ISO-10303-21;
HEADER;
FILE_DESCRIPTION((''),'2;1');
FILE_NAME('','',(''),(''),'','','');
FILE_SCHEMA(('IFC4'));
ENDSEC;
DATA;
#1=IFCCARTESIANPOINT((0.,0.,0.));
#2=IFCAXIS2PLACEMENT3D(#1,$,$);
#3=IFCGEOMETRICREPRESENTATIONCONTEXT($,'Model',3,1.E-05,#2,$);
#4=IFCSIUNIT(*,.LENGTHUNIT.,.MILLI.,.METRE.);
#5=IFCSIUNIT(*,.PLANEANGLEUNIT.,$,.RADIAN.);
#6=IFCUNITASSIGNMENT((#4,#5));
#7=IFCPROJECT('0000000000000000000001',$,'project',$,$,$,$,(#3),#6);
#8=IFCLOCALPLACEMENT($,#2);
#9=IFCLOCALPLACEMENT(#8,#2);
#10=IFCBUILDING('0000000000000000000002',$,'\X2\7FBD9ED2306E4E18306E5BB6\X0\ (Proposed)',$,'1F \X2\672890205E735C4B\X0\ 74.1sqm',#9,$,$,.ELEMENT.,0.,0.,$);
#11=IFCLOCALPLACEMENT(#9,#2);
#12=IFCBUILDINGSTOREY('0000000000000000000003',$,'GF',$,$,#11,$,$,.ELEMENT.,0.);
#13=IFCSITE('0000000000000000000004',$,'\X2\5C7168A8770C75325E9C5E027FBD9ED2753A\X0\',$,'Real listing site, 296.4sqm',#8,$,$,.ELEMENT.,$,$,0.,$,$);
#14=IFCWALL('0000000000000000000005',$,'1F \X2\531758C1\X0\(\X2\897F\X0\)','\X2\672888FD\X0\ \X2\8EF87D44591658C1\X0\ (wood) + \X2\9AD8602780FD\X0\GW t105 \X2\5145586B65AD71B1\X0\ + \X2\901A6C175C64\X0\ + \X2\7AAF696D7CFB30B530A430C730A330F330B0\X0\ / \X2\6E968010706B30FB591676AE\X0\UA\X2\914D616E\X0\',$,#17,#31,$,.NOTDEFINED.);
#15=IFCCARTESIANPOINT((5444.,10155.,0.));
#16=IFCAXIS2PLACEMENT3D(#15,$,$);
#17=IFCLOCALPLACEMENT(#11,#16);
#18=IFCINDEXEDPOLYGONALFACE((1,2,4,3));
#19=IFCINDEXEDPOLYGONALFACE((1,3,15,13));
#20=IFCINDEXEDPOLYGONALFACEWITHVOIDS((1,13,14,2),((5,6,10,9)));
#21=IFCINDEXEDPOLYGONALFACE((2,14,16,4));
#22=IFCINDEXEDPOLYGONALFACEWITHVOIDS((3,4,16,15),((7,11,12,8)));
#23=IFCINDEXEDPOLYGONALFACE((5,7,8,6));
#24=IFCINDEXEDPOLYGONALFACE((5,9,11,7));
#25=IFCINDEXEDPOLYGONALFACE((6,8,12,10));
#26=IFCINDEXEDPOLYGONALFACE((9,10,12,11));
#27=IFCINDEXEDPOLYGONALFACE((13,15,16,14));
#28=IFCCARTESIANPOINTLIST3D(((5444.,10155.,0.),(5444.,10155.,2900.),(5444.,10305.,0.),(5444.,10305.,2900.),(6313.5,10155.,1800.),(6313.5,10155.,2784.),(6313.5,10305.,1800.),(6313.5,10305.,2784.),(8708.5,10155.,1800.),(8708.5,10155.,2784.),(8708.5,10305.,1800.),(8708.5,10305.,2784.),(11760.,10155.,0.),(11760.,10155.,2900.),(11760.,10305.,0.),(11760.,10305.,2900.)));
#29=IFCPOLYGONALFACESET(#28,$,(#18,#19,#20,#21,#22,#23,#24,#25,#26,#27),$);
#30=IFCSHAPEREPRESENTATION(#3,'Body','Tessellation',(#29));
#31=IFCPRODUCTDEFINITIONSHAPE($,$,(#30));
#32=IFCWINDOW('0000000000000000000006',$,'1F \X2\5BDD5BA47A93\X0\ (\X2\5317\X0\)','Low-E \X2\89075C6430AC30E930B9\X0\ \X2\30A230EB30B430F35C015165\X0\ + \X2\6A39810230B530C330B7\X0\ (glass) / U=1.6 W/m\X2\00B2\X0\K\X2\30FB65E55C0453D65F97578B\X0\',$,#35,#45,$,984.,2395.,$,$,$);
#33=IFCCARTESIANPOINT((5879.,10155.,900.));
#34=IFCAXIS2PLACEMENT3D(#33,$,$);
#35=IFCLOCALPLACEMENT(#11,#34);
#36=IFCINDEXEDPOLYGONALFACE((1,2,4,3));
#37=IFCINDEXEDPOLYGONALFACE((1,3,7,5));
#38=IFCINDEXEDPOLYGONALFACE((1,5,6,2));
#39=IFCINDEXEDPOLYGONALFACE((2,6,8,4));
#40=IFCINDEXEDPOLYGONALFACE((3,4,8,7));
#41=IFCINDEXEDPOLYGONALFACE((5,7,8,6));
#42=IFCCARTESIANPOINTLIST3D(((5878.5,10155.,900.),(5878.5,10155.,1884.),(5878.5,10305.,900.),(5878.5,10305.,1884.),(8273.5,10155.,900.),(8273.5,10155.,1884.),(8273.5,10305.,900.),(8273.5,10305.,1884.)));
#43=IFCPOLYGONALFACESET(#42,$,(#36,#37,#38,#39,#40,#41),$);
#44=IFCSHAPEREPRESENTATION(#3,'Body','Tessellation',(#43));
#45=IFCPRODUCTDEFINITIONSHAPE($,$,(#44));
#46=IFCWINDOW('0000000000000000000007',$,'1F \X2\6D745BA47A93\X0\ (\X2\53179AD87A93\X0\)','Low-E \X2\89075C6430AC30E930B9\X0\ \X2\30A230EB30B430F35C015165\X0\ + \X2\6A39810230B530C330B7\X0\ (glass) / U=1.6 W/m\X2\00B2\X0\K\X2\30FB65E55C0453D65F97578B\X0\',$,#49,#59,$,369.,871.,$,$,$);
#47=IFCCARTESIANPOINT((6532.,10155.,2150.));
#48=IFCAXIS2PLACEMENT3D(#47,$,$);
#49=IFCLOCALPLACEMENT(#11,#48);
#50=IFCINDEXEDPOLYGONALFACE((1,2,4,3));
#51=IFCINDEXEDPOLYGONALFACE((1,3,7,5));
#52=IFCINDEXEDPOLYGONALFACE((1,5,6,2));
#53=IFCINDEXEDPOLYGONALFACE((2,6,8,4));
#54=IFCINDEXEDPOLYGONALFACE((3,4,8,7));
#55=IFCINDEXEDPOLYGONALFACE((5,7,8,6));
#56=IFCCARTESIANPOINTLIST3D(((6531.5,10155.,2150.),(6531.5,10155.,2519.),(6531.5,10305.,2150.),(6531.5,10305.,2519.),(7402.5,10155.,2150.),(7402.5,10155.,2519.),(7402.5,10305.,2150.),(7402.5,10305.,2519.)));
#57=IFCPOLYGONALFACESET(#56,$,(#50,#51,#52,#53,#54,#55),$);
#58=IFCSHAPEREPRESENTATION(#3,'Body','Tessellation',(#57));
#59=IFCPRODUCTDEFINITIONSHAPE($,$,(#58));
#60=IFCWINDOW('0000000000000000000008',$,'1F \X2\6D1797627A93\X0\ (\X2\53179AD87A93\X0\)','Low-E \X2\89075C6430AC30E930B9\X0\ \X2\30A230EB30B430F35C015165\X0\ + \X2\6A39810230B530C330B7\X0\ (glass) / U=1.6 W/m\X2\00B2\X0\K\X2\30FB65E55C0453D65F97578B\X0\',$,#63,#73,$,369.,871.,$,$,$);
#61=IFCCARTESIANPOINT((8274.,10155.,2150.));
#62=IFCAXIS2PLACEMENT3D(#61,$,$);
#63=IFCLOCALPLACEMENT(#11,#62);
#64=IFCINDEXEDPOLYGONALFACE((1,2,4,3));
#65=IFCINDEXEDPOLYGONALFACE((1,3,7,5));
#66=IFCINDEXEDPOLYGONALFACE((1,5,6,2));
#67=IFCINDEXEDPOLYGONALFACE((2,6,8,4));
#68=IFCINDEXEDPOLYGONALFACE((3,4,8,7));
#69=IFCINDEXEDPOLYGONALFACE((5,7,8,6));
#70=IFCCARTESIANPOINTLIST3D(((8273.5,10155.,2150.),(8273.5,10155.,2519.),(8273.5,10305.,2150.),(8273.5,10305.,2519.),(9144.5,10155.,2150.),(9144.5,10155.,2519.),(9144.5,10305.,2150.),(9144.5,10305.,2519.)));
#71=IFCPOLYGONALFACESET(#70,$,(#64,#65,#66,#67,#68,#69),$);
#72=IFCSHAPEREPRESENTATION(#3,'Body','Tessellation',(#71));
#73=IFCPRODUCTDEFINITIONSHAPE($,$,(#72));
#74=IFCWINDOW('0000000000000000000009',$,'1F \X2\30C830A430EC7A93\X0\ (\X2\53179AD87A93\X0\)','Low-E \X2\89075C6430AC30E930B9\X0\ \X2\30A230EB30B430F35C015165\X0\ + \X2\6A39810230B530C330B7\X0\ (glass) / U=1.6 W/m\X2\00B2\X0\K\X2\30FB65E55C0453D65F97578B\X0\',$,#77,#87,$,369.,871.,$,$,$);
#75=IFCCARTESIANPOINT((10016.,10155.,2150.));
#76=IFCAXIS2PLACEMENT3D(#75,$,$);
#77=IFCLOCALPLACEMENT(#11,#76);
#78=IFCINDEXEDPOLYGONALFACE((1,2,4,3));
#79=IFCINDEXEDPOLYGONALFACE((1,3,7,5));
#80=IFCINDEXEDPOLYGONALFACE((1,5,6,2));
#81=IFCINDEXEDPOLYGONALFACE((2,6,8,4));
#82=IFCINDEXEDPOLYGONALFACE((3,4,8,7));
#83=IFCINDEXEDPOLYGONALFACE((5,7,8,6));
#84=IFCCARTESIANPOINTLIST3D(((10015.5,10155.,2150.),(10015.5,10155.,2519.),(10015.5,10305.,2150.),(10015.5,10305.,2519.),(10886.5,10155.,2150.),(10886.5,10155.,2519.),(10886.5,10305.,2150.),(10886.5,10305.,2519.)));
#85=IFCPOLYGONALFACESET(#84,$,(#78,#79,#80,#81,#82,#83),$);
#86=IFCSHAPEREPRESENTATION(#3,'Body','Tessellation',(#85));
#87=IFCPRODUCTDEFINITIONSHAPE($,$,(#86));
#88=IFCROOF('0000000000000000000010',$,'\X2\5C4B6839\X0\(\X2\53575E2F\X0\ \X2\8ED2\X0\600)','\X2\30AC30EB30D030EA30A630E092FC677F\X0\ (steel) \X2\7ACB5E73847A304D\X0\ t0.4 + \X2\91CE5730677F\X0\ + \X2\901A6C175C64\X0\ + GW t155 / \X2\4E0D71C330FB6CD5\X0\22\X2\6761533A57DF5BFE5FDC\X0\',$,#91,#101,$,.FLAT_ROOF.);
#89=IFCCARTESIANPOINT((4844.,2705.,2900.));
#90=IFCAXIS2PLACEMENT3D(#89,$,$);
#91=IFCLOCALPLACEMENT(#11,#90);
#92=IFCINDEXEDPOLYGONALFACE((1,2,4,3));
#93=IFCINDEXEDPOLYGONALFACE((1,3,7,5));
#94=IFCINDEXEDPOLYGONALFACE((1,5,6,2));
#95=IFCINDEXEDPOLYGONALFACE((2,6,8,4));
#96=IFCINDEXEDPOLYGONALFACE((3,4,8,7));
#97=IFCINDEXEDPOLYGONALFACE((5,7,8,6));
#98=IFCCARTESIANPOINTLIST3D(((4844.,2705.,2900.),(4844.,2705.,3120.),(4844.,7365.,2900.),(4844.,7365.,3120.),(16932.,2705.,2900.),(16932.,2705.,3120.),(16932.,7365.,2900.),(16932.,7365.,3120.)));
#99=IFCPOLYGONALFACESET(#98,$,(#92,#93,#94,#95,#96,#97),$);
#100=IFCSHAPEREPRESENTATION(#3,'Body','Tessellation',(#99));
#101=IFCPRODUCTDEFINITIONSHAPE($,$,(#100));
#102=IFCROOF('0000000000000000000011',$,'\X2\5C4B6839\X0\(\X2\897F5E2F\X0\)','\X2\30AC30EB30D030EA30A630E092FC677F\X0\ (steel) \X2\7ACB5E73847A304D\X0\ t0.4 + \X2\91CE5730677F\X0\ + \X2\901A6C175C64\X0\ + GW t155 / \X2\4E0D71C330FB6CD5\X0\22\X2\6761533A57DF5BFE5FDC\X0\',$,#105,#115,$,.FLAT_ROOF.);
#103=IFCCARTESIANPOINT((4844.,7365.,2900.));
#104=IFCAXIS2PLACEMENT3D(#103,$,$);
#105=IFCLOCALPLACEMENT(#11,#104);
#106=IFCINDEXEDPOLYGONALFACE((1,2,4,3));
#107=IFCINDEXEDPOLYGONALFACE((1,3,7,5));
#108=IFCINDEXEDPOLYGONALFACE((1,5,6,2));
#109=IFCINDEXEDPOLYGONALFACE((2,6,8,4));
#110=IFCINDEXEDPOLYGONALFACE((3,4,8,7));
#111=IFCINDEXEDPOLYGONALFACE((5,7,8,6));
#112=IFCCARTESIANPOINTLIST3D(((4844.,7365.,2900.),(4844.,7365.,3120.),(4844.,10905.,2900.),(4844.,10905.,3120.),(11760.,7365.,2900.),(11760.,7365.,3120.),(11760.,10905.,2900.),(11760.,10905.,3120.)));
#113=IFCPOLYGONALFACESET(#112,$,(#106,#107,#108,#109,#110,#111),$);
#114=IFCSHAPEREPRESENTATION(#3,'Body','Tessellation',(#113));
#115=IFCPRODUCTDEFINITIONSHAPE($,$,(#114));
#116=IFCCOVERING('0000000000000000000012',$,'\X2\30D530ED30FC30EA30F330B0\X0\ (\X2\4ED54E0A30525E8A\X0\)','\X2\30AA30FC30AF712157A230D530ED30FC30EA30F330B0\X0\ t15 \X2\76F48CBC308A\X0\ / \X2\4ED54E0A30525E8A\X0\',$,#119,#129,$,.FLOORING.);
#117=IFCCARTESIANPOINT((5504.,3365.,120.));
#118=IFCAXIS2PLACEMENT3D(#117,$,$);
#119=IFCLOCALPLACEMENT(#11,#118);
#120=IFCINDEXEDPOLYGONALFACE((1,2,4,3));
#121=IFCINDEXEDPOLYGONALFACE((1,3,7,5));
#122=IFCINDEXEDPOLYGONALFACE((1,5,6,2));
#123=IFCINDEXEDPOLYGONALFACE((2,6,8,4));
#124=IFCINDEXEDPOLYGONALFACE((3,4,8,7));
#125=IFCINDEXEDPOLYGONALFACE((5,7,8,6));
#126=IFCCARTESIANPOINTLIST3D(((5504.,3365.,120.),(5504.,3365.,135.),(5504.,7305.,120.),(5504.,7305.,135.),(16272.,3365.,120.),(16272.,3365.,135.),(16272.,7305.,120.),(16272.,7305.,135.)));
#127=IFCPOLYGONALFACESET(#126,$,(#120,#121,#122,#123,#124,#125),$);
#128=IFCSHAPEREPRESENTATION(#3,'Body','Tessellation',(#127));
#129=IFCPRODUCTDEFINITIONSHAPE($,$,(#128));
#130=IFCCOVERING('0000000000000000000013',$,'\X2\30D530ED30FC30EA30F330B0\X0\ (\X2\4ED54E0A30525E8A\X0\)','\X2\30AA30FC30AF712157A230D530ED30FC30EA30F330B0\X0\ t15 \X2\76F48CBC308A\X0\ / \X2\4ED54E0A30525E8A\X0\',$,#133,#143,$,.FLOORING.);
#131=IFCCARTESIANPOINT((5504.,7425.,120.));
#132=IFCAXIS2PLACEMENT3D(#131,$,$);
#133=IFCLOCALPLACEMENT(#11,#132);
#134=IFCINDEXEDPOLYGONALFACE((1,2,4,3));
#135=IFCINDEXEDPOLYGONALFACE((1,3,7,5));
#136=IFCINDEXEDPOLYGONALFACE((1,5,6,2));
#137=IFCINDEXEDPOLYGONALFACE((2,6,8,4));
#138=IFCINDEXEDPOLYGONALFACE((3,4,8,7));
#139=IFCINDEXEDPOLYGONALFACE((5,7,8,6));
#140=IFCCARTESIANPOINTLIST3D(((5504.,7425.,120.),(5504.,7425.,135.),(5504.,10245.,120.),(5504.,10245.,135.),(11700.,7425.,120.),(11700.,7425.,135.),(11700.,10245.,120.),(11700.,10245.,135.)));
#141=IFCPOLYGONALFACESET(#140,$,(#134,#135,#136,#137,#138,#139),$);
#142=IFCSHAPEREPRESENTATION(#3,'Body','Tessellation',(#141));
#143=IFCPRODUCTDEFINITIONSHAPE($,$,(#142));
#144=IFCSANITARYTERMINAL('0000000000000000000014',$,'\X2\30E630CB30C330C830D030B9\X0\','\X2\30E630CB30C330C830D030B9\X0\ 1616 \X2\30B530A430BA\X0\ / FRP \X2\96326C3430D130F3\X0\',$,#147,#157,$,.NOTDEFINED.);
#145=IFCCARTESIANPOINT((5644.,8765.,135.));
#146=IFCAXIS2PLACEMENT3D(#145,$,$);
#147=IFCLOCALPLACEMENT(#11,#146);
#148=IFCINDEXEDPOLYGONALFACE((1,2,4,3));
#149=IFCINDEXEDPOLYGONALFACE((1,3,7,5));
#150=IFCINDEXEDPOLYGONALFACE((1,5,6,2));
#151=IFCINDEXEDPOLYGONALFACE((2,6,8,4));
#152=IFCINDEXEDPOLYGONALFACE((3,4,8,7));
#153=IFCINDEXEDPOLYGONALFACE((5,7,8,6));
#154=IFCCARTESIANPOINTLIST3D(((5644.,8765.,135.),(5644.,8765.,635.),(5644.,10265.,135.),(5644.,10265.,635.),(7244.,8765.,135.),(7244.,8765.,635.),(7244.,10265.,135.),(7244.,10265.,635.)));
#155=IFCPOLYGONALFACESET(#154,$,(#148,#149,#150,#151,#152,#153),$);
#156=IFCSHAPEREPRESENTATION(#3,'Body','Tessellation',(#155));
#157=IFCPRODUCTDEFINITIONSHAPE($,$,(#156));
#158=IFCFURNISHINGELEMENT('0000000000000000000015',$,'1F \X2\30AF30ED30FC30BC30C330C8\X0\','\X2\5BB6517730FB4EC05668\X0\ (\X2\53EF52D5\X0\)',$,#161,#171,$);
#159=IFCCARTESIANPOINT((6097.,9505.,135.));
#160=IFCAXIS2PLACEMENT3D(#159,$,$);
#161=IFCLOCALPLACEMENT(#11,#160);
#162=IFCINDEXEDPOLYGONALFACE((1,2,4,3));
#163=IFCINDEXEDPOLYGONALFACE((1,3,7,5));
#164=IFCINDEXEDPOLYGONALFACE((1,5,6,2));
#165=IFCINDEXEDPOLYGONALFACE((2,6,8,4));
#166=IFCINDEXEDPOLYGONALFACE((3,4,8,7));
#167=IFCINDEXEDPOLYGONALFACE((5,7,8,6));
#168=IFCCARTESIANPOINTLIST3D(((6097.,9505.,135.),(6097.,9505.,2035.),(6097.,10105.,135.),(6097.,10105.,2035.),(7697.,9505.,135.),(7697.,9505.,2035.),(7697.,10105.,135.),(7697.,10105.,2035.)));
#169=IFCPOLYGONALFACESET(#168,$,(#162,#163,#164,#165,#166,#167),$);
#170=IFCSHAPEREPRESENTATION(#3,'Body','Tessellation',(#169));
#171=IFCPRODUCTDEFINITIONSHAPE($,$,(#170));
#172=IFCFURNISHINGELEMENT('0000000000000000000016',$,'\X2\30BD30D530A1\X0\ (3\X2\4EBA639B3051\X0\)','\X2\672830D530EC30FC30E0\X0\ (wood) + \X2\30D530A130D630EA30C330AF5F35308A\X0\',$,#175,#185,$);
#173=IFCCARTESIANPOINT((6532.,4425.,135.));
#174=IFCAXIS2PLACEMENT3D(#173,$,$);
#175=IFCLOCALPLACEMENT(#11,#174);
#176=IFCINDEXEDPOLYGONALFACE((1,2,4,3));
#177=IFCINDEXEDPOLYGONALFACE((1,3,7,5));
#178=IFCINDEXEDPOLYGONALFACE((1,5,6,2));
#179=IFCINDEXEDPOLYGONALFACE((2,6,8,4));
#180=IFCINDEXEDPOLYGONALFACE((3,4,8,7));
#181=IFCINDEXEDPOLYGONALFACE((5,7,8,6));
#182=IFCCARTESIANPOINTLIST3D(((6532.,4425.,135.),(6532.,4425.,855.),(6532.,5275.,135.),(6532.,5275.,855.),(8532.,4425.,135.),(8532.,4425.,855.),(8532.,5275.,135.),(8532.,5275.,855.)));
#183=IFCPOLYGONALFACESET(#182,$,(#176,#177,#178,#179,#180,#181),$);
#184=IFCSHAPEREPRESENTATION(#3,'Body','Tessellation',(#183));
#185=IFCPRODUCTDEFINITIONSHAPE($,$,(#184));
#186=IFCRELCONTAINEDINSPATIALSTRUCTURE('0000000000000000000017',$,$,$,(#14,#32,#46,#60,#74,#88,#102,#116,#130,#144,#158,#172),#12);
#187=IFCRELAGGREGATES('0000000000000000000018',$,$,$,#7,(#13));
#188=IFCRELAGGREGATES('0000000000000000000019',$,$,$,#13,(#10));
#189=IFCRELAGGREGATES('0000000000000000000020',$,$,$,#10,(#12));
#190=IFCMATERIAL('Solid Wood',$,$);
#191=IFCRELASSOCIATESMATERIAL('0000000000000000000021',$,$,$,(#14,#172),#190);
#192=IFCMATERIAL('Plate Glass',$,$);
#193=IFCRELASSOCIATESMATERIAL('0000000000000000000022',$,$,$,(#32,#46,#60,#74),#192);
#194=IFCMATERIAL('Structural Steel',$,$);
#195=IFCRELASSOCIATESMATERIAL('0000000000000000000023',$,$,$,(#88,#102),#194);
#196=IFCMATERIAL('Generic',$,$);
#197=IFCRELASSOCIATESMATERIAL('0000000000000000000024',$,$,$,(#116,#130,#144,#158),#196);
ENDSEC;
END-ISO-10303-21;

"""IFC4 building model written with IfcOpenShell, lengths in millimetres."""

from ifc_helpers import new_model, si_unit, frame, frame_2d, origin, place, context, project, spatial, rectangle, extrude, material, element, fill, save


model = new_model("IFC4")

# Units and contexts
model_context = context("Model", 3, precision=1e-05, world=origin())
ifc_project = project(units=[si_unit("LENGTHUNIT", "METRE", prefix="MILLI"), si_unit("PLANEANGLEUNIT", "RADIAN")], contexts=[model_context])

# Site, building, storey
site_placement = place(None, origin())
site = spatial("IfcSite", under=ifc_project, at=site_placement, Name="山梨県甲府市羽黒町", ObjectType="Real listing site, 296.4sqm", CompositionType="ELEMENT", RefElevation=0.0)
building_placement = place(site_placement, origin())
building = spatial("IfcBuilding", under=site, at=building_placement, Name="羽黒の丘の家 (Proposed)", ObjectType="1F 木造平屋 74.1sqm", CompositionType="ELEMENT", ElevationOfRefHeight=0.0, ElevationOfTerrain=0.0)
storey_placement = place(building_placement, origin())
storey = spatial("IfcBuildingStorey", under=building, at=storey_placement, Name="GF", CompositionType="ELEMENT", Elevation=0.0)

# Shared definitions
ifc_material_1 = material(Name="Solid Wood")

# Shared definitions
ifc_material_2 = material(Name="Plate Glass")

# Wall, openings, windows
wall_1_placement = place(storey_placement, frame((5444.0, 10155.0, 0.0)))
wall_1 = element("IfcWall", 1, at=wall_1_placement, inside=storey, material=ifc_material_1, Name="1F 北壁(西)", Description="木製 軸組外壁 (wood) + 高性能GW t105 充填断熱 + 通気層 + 窯業系サイディング / 準耐火・外皮UA配慮", PredefinedType="NOTDEFINED", context=model_context, shape_type="SweptSolid", body=[
    extrude(rectangle(XDim=6316.0, YDim=150.0, at=frame_2d((3158.0, 75.0))), frame((5444.0, 10155.0, 0.0)), (0.0, 0.0, 1.0), 2900.0),
])
opening_1_placement = place(storey_placement, frame((5879.0, 10155.0, 900.0)))
opening_1 = element("IfcOpeningElement", 2, at=opening_1_placement, cuts=wall_1, PredefinedType="NOTDEFINED", context=model_context, shape_type="SweptSolid", body=[
    extrude(rectangle(XDim=2395.0, YDim=150.0, at=frame_2d((1197.0, 75.0))), frame((5879.0, 10155.0, 900.0)), (0.0, 0.0, 1.0), 984.0),
])
opening_2_placement = place(storey_placement, frame((6532.0, 10155.0, 2150.0)))
opening_2 = element("IfcOpeningElement", 3, at=opening_2_placement, cuts=wall_1, PredefinedType="NOTDEFINED", context=model_context, shape_type="SweptSolid", body=[
    extrude(rectangle(XDim=871.0, YDim=150.0, at=frame_2d((435.0, 75.0))), frame((6532.0, 10155.0, 2150.0)), (0.0, 0.0, 1.0), 369.0),
])
opening_3_placement = place(storey_placement, frame((8274.0, 10155.0, 2150.0)))
opening_3 = element("IfcOpeningElement", 4, at=opening_3_placement, cuts=wall_1, PredefinedType="NOTDEFINED", context=model_context, shape_type="SweptSolid", body=[
    extrude(rectangle(XDim=871.0, YDim=150.0, at=frame_2d((435.0, 75.0))), frame((8274.0, 10155.0, 2150.0)), (0.0, 0.0, 1.0), 369.0),
])
opening_4_placement = place(storey_placement, frame((10016.0, 10155.0, 2150.0)))
opening_4 = element("IfcOpeningElement", 5, at=opening_4_placement, cuts=wall_1, PredefinedType="NOTDEFINED", context=model_context, shape_type="SweptSolid", body=[
    extrude(rectangle(XDim=871.0, YDim=150.0, at=frame_2d((435.0, 75.0))), frame((10016.0, 10155.0, 2150.0)), (0.0, 0.0, 1.0), 369.0),
])
window_1_placement = place(storey_placement, frame((5879.0, 10155.0, 900.0)))
window_1 = element("IfcWindow", 6, at=window_1_placement, inside=storey, material=ifc_material_2, Name="1F 寝室窓 (北)", Description="Low-E 複層ガラス アルゴン封入 + 樹脂サッシ (glass) / U=1.6 W/m²K・日射取得型", OverallHeight=984.0, OverallWidth=2395.0, context=model_context, shape_type="SweptSolid", body=[
    extrude(rectangle(XDim=2395.0, YDim=150.0, at=frame_2d((1197.0, 75.0))), frame((5879.0, 10155.0, 900.0)), (0.0, 0.0, 1.0), 984.0),
])
fill(opening_1, window_1)
window_2_placement = place(storey_placement, frame((6532.0, 10155.0, 2150.0)))
window_2 = element("IfcWindow", 7, at=window_2_placement, inside=storey, material=ifc_material_2, Name="1F 浴室窓 (北高窓)", Description="Low-E 複層ガラス アルゴン封入 + 樹脂サッシ (glass) / U=1.6 W/m²K・日射取得型", OverallHeight=369.0, OverallWidth=871.0, context=model_context, shape_type="SweptSolid", body=[
    extrude(rectangle(XDim=871.0, YDim=150.0, at=frame_2d((435.0, 75.0))), frame((6532.0, 10155.0, 2150.0)), (0.0, 0.0, 1.0), 369.0),
])
fill(opening_2, window_2)
window_3_placement = place(storey_placement, frame((8274.0, 10155.0, 2150.0)))
window_3 = element("IfcWindow", 8, at=window_3_placement, inside=storey, material=ifc_material_2, Name="1F 洗面窓 (北高窓)", Description="Low-E 複層ガラス アルゴン封入 + 樹脂サッシ (glass) / U=1.6 W/m²K・日射取得型", OverallHeight=369.0, OverallWidth=871.0, context=model_context, shape_type="SweptSolid", body=[
    extrude(rectangle(XDim=871.0, YDim=150.0, at=frame_2d((435.0, 75.0))), frame((8274.0, 10155.0, 2150.0)), (0.0, 0.0, 1.0), 369.0),
])
fill(opening_3, window_3)
window_4_placement = place(storey_placement, frame((10016.0, 10155.0, 2150.0)))
window_4 = element("IfcWindow", 9, at=window_4_placement, inside=storey, material=ifc_material_2, Name="1F トイレ窓 (北高窓)", Description="Low-E 複層ガラス アルゴン封入 + 樹脂サッシ (glass) / U=1.6 W/m²K・日射取得型", OverallHeight=369.0, OverallWidth=871.0, context=model_context, shape_type="SweptSolid", body=[
    extrude(rectangle(XDim=871.0, YDim=150.0, at=frame_2d((435.0, 75.0))), frame((10016.0, 10155.0, 2150.0)), (0.0, 0.0, 1.0), 369.0),
])
fill(opening_4, window_4)

# Roofs
ifc_material_3 = material(Name="Structural Steel")
roof_1_placement = place(storey_placement, frame((4844.0, 2705.0, 2900.0)))
element("IfcRoof", 10, at=roof_1_placement, inside=storey, material=ifc_material_3, Name="屋根(南帯 軒600)", Description="ガルバリウム鋼板 (steel) 立平葺き t0.4 + 野地板 + 通気層 + GW t155 / 不燃・法22条区域対応", PredefinedType="FLAT_ROOF", context=model_context, shape_type="SweptSolid", body=[
    extrude(rectangle(XDim=12088.0, YDim=4660.0, at=frame_2d((6044.0, 2330.0))), frame((4844.0, 2705.0, 2900.0)), (0.0, 0.0, 1.0), 220.0),
])
roof_2_placement = place(storey_placement, frame((4844.0, 7365.0, 2900.0)))
element("IfcRoof", 11, at=roof_2_placement, inside=storey, material=ifc_material_3, Name="屋根(西帯)", Description="ガルバリウム鋼板 (steel) 立平葺き t0.4 + 野地板 + 通気層 + GW t155 / 不燃・法22条区域対応", PredefinedType="FLAT_ROOF", context=model_context, shape_type="SweptSolid", body=[
    extrude(rectangle(XDim=6916.0, YDim=3540.0, at=frame_2d((3458.0, 1770.0))), frame((4844.0, 7365.0, 2900.0)), (0.0, 0.0, 1.0), 220.0),
])

# Coverings
ifc_material_4 = material(Name="Generic")
covering_1_placement = place(storey_placement, frame((5504.0, 3365.0, 120.0)))
element("IfcCovering", 12, at=covering_1_placement, inside=storey, material=ifc_material_4, Name="フローリング (仕上げ床)", Description="オーク無垢フローリング t15 直貼り / 仕上げ床", PredefinedType="FLOORING", context=model_context, shape_type="SweptSolid", body=[
    extrude(rectangle(XDim=10768.0, YDim=3940.0, at=frame_2d((5384.0, 1970.0))), frame((5504.0, 3365.0, 120.0)), (0.0, 0.0, 1.0), 15.0),
])
covering_2_placement = place(storey_placement, frame((5504.0, 7425.0, 120.0)))
element("IfcCovering", 13, at=covering_2_placement, inside=storey, material=ifc_material_4, Name="フローリング (仕上げ床)", Description="オーク無垢フローリング t15 直貼り / 仕上げ床", PredefinedType="FLOORING", context=model_context, shape_type="SweptSolid", body=[
    extrude(rectangle(XDim=6196.0, YDim=2820.0, at=frame_2d((3098.0, 1410.0))), frame((5504.0, 7425.0, 120.0)), (0.0, 0.0, 1.0), 15.0),
])

# Sanitary terminal
sanitary_terminal_placement = place(storey_placement, frame((5644.0, 8765.0, 135.0)))
element("IfcSanitaryTerminal", 14, at=sanitary_terminal_placement, inside=storey, material=ifc_material_4, Name="ユニットバス", Description="ユニットバス 1616 サイズ / FRP 防水パン", PredefinedType="NOTDEFINED", context=model_context, shape_type="SweptSolid", body=[
    extrude(rectangle(XDim=1600.0, YDim=1500.0, at=frame_2d((800.0, 750.0))), frame((5644.0, 8765.0, 135.0)), (0.0, 0.0, 1.0), 500.0),
])

# Furnishing elements
furnishing_1_placement = place(storey_placement, frame((6097.0, 9505.0, 135.0)))
element("IfcFurnishingElement", 15, at=furnishing_1_placement, inside=storey, material=ifc_material_4, Name="1F クローゼット", Description="家具・什器 (可動)", context=model_context, shape_type="SweptSolid", body=[
    extrude(rectangle(XDim=1600.0, YDim=600.0, at=frame_2d((800.0, 300.0))), frame((6097.0, 9505.0, 135.0)), (0.0, 0.0, 1.0), 1900.0),
])
furnishing_2_placement = place(storey_placement, frame((6532.0, 4425.0, 135.0)))
element("IfcFurnishingElement", 16, at=furnishing_2_placement, inside=storey, material=ifc_material_1, Name="ソファ (3人掛け)", Description="木フレーム (wood) + ファブリック張り", context=model_context, shape_type="SweptSolid", body=[
    extrude(rectangle(XDim=2000.0, YDim=850.0, at=frame_2d((1000.0, 425.0))), frame((6532.0, 4425.0, 135.0)), (0.0, 0.0, 1.0), 720.0),
])

save(model, "model.ifc")
